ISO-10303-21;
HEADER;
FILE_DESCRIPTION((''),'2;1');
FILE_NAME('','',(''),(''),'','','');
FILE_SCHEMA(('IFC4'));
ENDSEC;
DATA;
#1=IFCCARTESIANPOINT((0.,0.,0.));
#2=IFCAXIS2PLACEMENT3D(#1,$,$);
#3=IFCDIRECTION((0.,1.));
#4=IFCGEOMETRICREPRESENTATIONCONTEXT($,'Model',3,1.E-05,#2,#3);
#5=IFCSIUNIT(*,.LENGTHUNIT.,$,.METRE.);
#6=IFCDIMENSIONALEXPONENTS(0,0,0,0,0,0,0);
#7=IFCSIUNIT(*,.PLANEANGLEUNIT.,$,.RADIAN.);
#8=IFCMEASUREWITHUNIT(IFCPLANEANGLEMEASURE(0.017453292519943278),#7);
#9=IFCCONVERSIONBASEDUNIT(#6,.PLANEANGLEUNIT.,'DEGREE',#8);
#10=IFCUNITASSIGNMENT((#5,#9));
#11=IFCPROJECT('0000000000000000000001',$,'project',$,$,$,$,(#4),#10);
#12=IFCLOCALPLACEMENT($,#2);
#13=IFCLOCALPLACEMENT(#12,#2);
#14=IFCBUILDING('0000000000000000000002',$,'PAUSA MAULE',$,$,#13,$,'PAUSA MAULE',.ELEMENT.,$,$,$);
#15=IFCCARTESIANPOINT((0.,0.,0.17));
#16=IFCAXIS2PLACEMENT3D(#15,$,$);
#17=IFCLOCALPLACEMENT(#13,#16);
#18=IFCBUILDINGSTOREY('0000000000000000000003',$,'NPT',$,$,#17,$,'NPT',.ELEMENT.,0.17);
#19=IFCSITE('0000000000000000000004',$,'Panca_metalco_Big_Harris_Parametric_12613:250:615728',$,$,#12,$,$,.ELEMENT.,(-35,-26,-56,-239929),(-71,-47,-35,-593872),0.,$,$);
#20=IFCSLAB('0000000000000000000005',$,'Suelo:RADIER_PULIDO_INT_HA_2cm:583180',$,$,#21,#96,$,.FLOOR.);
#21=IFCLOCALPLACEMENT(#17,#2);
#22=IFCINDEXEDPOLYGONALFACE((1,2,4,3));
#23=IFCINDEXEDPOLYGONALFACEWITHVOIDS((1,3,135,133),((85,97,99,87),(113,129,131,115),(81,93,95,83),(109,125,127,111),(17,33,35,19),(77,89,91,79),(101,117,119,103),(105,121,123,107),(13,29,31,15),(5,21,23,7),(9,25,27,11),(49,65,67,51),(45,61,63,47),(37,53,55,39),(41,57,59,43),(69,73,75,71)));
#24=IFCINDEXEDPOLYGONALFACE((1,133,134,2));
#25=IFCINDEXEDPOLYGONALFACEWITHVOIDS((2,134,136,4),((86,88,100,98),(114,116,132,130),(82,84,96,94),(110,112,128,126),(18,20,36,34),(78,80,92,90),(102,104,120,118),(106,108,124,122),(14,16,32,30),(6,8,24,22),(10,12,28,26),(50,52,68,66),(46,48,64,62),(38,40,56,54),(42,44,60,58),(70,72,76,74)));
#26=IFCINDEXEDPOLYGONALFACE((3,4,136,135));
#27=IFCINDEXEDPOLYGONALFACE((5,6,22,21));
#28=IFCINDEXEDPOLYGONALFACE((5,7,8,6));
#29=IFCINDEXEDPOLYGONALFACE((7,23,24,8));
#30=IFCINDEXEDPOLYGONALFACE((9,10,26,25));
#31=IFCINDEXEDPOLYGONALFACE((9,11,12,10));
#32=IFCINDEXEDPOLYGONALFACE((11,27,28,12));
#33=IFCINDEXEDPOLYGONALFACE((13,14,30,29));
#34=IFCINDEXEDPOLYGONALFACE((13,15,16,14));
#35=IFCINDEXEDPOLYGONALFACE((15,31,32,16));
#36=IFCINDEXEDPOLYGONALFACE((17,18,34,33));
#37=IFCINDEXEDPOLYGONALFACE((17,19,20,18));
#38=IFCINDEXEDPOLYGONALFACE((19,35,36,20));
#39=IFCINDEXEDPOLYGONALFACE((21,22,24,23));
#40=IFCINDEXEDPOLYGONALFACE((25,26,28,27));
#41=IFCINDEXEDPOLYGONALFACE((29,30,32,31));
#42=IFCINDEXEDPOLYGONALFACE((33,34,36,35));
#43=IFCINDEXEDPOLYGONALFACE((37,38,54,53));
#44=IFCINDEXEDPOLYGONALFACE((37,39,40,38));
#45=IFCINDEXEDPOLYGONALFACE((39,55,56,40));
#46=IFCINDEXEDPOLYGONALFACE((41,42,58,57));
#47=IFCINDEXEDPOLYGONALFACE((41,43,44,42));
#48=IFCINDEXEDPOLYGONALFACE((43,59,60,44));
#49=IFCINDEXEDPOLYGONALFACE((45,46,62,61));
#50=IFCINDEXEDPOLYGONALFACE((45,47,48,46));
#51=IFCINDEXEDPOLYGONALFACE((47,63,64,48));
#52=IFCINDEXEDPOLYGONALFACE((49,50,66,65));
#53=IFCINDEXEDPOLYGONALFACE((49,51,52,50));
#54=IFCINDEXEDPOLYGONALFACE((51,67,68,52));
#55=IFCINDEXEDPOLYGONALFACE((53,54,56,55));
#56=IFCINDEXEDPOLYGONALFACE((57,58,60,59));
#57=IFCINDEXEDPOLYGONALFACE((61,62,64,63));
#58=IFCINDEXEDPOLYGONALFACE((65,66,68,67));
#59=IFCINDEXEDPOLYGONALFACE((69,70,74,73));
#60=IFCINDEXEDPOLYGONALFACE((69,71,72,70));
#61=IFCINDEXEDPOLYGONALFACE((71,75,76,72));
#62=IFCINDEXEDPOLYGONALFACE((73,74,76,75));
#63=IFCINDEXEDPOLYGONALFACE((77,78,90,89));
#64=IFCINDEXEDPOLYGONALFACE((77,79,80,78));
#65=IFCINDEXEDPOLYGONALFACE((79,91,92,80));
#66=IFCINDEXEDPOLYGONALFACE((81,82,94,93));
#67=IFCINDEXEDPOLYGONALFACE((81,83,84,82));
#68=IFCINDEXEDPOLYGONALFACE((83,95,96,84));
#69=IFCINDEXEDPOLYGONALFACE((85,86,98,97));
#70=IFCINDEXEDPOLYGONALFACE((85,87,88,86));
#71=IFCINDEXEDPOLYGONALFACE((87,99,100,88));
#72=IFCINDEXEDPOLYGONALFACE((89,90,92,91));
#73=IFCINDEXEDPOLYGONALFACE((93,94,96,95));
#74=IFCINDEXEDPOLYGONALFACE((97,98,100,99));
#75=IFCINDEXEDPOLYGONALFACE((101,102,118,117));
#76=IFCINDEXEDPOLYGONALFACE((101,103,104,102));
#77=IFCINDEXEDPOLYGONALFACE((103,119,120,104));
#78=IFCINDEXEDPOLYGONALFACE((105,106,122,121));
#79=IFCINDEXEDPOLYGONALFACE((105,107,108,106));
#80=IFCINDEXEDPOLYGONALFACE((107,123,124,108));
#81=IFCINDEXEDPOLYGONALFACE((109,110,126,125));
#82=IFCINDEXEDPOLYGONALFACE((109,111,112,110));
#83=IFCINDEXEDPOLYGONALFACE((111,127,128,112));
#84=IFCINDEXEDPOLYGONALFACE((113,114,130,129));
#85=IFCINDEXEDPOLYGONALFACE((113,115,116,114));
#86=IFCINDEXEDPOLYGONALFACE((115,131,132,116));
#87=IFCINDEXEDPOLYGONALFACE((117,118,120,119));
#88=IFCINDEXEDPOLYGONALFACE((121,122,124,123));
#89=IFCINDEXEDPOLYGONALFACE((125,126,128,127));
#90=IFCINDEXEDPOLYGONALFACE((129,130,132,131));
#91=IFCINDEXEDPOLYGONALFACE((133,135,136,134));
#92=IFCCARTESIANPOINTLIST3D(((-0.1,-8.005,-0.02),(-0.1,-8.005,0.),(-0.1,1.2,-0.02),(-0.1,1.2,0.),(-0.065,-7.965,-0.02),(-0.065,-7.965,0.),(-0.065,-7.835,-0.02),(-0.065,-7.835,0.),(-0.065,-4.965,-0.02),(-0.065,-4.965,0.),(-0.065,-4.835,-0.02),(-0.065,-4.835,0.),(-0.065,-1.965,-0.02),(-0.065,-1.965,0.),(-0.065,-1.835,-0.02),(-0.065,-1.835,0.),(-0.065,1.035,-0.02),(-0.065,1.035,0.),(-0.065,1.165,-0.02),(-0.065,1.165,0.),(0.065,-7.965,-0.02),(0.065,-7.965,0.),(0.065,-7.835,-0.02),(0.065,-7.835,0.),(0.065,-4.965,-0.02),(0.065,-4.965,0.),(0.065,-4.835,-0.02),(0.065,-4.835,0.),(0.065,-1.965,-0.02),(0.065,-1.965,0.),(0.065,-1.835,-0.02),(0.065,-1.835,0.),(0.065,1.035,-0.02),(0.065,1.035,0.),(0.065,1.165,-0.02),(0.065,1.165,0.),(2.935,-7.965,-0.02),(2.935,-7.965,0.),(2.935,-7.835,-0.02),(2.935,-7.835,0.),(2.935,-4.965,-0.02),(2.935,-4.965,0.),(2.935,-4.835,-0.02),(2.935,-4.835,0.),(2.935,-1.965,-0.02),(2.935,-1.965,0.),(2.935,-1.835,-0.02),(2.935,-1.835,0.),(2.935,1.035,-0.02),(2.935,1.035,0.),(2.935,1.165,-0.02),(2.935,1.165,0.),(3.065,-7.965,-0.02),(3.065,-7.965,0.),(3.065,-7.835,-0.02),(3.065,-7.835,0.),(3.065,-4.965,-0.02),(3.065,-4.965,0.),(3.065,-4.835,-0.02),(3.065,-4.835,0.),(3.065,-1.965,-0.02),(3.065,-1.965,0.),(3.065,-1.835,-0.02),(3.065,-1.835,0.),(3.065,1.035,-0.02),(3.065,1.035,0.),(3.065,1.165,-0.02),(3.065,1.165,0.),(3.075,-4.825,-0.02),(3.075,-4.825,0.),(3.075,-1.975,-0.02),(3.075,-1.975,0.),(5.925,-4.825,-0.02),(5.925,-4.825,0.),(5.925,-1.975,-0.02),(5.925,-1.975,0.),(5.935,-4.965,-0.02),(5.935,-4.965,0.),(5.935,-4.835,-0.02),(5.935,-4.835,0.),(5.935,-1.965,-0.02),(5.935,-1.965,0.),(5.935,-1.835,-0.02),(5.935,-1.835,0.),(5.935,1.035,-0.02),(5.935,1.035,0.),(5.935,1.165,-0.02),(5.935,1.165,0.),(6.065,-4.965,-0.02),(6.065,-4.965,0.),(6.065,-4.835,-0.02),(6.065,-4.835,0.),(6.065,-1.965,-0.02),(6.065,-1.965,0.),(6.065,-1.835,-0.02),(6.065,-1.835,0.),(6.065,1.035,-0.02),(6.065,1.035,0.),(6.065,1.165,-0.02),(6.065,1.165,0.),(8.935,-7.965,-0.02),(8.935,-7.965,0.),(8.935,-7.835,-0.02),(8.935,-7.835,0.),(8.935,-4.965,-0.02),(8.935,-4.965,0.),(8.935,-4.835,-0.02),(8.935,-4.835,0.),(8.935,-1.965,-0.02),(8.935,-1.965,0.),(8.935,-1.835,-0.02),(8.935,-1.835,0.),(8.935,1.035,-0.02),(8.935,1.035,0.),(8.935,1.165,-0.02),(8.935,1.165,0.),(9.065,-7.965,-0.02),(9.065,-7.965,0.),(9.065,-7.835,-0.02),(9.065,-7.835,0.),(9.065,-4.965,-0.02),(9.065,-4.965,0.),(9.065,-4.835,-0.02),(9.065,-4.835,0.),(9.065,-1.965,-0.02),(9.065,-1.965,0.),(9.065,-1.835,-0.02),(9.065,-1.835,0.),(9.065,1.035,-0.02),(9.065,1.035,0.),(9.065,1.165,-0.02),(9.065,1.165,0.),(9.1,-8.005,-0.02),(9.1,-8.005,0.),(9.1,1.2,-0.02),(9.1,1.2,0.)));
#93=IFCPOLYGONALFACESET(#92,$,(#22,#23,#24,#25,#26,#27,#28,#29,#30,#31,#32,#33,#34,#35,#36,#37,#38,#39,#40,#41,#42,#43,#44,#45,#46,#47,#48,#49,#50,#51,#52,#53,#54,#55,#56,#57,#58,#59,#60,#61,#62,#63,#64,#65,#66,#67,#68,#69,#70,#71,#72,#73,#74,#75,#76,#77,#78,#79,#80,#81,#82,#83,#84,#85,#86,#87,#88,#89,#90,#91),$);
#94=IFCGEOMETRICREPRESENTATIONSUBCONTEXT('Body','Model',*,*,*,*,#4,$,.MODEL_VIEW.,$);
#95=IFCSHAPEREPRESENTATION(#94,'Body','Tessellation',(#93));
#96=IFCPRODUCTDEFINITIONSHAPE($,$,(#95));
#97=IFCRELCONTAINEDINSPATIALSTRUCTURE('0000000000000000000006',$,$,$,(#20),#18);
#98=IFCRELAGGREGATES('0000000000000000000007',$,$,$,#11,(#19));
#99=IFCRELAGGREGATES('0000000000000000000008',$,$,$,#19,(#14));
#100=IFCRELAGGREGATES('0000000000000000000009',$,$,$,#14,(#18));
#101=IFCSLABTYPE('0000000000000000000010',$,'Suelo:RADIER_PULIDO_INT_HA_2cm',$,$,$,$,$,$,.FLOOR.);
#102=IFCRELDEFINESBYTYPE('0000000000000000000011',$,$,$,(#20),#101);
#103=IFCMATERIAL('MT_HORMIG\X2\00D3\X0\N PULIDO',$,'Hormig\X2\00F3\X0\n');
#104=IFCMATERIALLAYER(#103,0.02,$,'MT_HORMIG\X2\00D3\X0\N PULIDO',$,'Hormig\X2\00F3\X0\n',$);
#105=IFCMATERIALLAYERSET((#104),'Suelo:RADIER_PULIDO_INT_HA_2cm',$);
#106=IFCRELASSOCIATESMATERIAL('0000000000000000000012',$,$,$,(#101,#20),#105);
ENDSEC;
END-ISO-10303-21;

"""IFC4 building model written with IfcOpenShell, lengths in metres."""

from ifc_helpers import new_model, entity, si_unit, converted_unit, direction, frame, frame_2d, origin, origin_2d_with_axis, place, context, subcontext, project, spatial, rectangle, extrude, boolean, material, layer, layer_set, layer_usage, type_object, element, save


model = new_model("IFC4")

# Units and contexts
model_context = context("Model", 3, precision=1e-05, world=origin(), true_north=direction((0.0, 1.0)))
body_context = subcontext(model_context, "Body", "Model", "MODEL_VIEW")
ifc_project = project(units=[si_unit("LENGTHUNIT", "METRE"), converted_unit("PLANEANGLEUNIT", "DEGREE", entity("IfcPlaneAngleMeasure", 0.017453292519943278), si_unit("PLANEANGLEUNIT", "RADIAN"), dimensions=[0, 0, 0, 0, 0, 0, 0])], contexts=[model_context])

# Site, building, storey
site_placement = place(None, origin())
site = spatial("IfcSite", under=ifc_project, at=site_placement, Name="Panca_metalco_Big_Harris_Parametric_12613:250:615728", CompositionType="ELEMENT", RefLatitude=(-35, -26, -56, -239929), RefLongitude=(-71, -47, -35, -593872), RefElevation=0.0)
building_placement = place(site_placement, origin())
building = spatial("IfcBuilding", under=site, at=building_placement, Name="PAUSA MAULE", LongName="PAUSA MAULE", CompositionType="ELEMENT")
storey_placement = place(building_placement, frame((0.0, 0.0, 0.17)))
storey = spatial("IfcBuildingStorey", under=building, at=storey_placement, Name="NPT", LongName="NPT", CompositionType="ELEMENT", Elevation=0.17)

# Slab, opening
ifc_material_1 = material(Name="MT_HORMIGÓN PULIDO", Category="Hormigón")
ifc_layer = layer(ifc_material_1, 0.02, Name="MT_HORMIGÓN PULIDO", Category="Hormigón")
ifc_layer_set = layer_set([ifc_layer], Name="Suelo:RADIER_PULIDO_INT_HA_2cm")
ifc_layer_usage = layer_usage(ifc_layer_set, "AXIS3", "POSITIVE", 0.0)
slab_type = type_object("IfcSlabType", Name="Suelo:RADIER_PULIDO_INT_HA_2cm", PredefinedType="FLOOR", material=ifc_layer_set)
slab_placement = place(storey_placement, origin())
solid = boolean("DIFFERENCE", boolean("DIFFERENCE", boolean("DIFFERENCE", boolean("DIFFERENCE", boolean("DIFFERENCE", boolean("DIFFERENCE", boolean("DIFFERENCE", boolean("DIFFERENCE", extrude(rectangle(XDim=9.205, YDim=9.2, at=origin_2d_with_axis()), frame((4.5, -3.4025, 0.0), z_axis=(0.0, 0.0, -1.0), x_axis=(0.0, 1.0, 0.0)), (0.0, 0.0, 1.0), 0.02), extrude(rectangle(XDim=2.85, YDim=2.85, at=origin_2d_with_axis()), frame((4.5, -3.4, -0.02), z_axis=(0.0, 0.0, 1.0), x_axis=(0.0, 1.0, 0.0)), (0.0, 0.0, 1.0), 0.02)), extrude(rectangle(XDim=0.13, YDim=0.13, at=origin_2d_with_axis()), frame((0.0, -7.9, -0.02), z_axis=(0.0, 0.0, 1.0), x_axis=(0.0, 1.0, 0.0)), (0.0, 0.0, 1.0), 0.02)), extrude(rectangle(XDim=0.13, YDim=0.13, at=origin_2d_with_axis()), frame((0.0, -4.9, -0.02), z_axis=(0.0, 0.0, 1.0), x_axis=(0.0, 1.0, 0.0)), (0.0, 0.0, 1.0), 0.02)), extrude(rectangle(XDim=0.13, YDim=0.13, at=origin_2d_with_axis()), frame((0.0, -1.9, -0.02), z_axis=(0.0, 0.0, 1.0), x_axis=(0.0, 1.0, 0.0)), (0.0, 0.0, 1.0), 0.02)), extrude(rectangle(XDim=0.13, YDim=0.13, at=origin_2d_with_axis()), frame((0.0, 1.1, -0.02), z_axis=(0.0, 0.0, 1.0), x_axis=(0.0, 1.0, 0.0)), (0.0, 0.0, 1.0), 0.02)), extrude(rectangle(XDim=0.13, YDim=0.13, at=origin_2d_with_axis()), frame((3.0, -7.9, -0.02), z_axis=(0.0, 0.0, 1.0), x_axis=(0.0, 1.0, 0.0)), (0.0, 0.0, 1.0), 0.02)), extrude(rectangle(XDim=0.13, YDim=0.13, at=origin_2d_with_axis()), frame((3.0, -4.9, -0.02), z_axis=(0.0, 0.0, 1.0), x_axis=(0.0, 1.0, 0.0)), (0.0, 0.0, 1.0), 0.02)), extrude(rectangle(XDim=0.13, YDim=0.13, at=origin_2d_with_axis()), frame((3.0, -1.9, -0.02), z_axis=(0.0, 0.0, 1.0), x_axis=(0.0, 1.0, 0.0)), (0.0, 0.0, 1.0), 0.02))
slab = element("IfcSlab", 1, at=slab_placement, inside=storey, type_object=slab_type, material=ifc_layer_usage, Name="Suelo:RADIER_PULIDO_INT_HA_2cm:583180", PredefinedType="FLOOR", context=body_context, shape_type="CSG", body=[
    boolean("DIFFERENCE", boolean("DIFFERENCE", boolean("DIFFERENCE", boolean("DIFFERENCE", boolean("DIFFERENCE", boolean("DIFFERENCE", boolean("DIFFERENCE", boolean("DIFFERENCE", solid, extrude(rectangle(XDim=0.13, YDim=0.13, at=origin_2d_with_axis()), frame((3.0, 1.1, -0.02), z_axis=(0.0, 0.0, 1.0), x_axis=(0.0, 1.0, 0.0)), (0.0, 0.0, 1.0), 0.02)), extrude(rectangle(XDim=0.13, YDim=0.13, at=frame_2d((0.0, 0.0), x_axis=(1.0, 0.0))), frame((6.0, -4.9, -0.02), z_axis=(0.0, 0.0, 1.0), x_axis=(0.0, 1.0, 0.0)), (0.0, 0.0, 1.0), 0.02)), extrude(rectangle(XDim=0.13, YDim=0.13, at=frame_2d((0.0, 0.0), x_axis=(1.0, 0.0))), frame((6.0, -1.9, -0.02), z_axis=(0.0, 0.0, 1.0), x_axis=(0.0, 1.0, 0.0)), (0.0, 0.0, 1.0), 0.02)), extrude(rectangle(XDim=0.13, YDim=0.13, at=frame_2d((0.0, 0.0), x_axis=(1.0, 0.0))), frame((6.0, 1.1, -0.02), z_axis=(0.0, 0.0, 1.0), x_axis=(0.0, 1.0, 0.0)), (0.0, 0.0, 1.0), 0.02)), extrude(rectangle(XDim=0.13, YDim=0.13, at=frame_2d((0.0, 0.0), x_axis=(1.0, 0.0))), frame((9.0, -7.9, -0.02), z_axis=(0.0, 0.0, 1.0), x_axis=(0.0, 1.0, 0.0)), (0.0, 0.0, 1.0), 0.02)), extrude(rectangle(XDim=0.13, YDim=0.13, at=frame_2d((0.0, 0.0), x_axis=(1.0, 0.0))), frame((9.0, -4.9, -0.02), z_axis=(0.0, 0.0, 1.0), x_axis=(0.0, 1.0, 0.0)), (0.0, 0.0, 1.0), 0.02)), extrude(rectangle(XDim=0.13, YDim=0.13, at=frame_2d((0.0, 0.0), x_axis=(1.0, 0.0))), frame((9.0, -1.9, -0.02), z_axis=(0.0, 0.0, 1.0), x_axis=(0.0, 1.0, 0.0)), (0.0, 0.0, 1.0), 0.02)), extrude(rectangle(XDim=0.13, YDim=0.13, at=frame_2d((0.0, 0.0), x_axis=(1.0, 0.0))), frame((9.0, 1.1, -0.02), z_axis=(0.0, 0.0, 1.0), x_axis=(0.0, 1.0, 0.0)), (0.0, 0.0, 1.0), 0.02)),
])
opening_placement = place(slab_placement, origin())
element("IfcOpeningElement", 2, at=opening_placement, cuts=slab, PredefinedType="OPENING", context=body_context, shape_type="SweptSolid", body=[
    extrude(rectangle(XDim=2.85, YDim=2.85, at=frame_2d((4.5, -3.4), x_axis=(0.0, -1.0))), origin(), (0.0, 0.0, -1.0), 0.02),
])

save(model, "model.ifc")
